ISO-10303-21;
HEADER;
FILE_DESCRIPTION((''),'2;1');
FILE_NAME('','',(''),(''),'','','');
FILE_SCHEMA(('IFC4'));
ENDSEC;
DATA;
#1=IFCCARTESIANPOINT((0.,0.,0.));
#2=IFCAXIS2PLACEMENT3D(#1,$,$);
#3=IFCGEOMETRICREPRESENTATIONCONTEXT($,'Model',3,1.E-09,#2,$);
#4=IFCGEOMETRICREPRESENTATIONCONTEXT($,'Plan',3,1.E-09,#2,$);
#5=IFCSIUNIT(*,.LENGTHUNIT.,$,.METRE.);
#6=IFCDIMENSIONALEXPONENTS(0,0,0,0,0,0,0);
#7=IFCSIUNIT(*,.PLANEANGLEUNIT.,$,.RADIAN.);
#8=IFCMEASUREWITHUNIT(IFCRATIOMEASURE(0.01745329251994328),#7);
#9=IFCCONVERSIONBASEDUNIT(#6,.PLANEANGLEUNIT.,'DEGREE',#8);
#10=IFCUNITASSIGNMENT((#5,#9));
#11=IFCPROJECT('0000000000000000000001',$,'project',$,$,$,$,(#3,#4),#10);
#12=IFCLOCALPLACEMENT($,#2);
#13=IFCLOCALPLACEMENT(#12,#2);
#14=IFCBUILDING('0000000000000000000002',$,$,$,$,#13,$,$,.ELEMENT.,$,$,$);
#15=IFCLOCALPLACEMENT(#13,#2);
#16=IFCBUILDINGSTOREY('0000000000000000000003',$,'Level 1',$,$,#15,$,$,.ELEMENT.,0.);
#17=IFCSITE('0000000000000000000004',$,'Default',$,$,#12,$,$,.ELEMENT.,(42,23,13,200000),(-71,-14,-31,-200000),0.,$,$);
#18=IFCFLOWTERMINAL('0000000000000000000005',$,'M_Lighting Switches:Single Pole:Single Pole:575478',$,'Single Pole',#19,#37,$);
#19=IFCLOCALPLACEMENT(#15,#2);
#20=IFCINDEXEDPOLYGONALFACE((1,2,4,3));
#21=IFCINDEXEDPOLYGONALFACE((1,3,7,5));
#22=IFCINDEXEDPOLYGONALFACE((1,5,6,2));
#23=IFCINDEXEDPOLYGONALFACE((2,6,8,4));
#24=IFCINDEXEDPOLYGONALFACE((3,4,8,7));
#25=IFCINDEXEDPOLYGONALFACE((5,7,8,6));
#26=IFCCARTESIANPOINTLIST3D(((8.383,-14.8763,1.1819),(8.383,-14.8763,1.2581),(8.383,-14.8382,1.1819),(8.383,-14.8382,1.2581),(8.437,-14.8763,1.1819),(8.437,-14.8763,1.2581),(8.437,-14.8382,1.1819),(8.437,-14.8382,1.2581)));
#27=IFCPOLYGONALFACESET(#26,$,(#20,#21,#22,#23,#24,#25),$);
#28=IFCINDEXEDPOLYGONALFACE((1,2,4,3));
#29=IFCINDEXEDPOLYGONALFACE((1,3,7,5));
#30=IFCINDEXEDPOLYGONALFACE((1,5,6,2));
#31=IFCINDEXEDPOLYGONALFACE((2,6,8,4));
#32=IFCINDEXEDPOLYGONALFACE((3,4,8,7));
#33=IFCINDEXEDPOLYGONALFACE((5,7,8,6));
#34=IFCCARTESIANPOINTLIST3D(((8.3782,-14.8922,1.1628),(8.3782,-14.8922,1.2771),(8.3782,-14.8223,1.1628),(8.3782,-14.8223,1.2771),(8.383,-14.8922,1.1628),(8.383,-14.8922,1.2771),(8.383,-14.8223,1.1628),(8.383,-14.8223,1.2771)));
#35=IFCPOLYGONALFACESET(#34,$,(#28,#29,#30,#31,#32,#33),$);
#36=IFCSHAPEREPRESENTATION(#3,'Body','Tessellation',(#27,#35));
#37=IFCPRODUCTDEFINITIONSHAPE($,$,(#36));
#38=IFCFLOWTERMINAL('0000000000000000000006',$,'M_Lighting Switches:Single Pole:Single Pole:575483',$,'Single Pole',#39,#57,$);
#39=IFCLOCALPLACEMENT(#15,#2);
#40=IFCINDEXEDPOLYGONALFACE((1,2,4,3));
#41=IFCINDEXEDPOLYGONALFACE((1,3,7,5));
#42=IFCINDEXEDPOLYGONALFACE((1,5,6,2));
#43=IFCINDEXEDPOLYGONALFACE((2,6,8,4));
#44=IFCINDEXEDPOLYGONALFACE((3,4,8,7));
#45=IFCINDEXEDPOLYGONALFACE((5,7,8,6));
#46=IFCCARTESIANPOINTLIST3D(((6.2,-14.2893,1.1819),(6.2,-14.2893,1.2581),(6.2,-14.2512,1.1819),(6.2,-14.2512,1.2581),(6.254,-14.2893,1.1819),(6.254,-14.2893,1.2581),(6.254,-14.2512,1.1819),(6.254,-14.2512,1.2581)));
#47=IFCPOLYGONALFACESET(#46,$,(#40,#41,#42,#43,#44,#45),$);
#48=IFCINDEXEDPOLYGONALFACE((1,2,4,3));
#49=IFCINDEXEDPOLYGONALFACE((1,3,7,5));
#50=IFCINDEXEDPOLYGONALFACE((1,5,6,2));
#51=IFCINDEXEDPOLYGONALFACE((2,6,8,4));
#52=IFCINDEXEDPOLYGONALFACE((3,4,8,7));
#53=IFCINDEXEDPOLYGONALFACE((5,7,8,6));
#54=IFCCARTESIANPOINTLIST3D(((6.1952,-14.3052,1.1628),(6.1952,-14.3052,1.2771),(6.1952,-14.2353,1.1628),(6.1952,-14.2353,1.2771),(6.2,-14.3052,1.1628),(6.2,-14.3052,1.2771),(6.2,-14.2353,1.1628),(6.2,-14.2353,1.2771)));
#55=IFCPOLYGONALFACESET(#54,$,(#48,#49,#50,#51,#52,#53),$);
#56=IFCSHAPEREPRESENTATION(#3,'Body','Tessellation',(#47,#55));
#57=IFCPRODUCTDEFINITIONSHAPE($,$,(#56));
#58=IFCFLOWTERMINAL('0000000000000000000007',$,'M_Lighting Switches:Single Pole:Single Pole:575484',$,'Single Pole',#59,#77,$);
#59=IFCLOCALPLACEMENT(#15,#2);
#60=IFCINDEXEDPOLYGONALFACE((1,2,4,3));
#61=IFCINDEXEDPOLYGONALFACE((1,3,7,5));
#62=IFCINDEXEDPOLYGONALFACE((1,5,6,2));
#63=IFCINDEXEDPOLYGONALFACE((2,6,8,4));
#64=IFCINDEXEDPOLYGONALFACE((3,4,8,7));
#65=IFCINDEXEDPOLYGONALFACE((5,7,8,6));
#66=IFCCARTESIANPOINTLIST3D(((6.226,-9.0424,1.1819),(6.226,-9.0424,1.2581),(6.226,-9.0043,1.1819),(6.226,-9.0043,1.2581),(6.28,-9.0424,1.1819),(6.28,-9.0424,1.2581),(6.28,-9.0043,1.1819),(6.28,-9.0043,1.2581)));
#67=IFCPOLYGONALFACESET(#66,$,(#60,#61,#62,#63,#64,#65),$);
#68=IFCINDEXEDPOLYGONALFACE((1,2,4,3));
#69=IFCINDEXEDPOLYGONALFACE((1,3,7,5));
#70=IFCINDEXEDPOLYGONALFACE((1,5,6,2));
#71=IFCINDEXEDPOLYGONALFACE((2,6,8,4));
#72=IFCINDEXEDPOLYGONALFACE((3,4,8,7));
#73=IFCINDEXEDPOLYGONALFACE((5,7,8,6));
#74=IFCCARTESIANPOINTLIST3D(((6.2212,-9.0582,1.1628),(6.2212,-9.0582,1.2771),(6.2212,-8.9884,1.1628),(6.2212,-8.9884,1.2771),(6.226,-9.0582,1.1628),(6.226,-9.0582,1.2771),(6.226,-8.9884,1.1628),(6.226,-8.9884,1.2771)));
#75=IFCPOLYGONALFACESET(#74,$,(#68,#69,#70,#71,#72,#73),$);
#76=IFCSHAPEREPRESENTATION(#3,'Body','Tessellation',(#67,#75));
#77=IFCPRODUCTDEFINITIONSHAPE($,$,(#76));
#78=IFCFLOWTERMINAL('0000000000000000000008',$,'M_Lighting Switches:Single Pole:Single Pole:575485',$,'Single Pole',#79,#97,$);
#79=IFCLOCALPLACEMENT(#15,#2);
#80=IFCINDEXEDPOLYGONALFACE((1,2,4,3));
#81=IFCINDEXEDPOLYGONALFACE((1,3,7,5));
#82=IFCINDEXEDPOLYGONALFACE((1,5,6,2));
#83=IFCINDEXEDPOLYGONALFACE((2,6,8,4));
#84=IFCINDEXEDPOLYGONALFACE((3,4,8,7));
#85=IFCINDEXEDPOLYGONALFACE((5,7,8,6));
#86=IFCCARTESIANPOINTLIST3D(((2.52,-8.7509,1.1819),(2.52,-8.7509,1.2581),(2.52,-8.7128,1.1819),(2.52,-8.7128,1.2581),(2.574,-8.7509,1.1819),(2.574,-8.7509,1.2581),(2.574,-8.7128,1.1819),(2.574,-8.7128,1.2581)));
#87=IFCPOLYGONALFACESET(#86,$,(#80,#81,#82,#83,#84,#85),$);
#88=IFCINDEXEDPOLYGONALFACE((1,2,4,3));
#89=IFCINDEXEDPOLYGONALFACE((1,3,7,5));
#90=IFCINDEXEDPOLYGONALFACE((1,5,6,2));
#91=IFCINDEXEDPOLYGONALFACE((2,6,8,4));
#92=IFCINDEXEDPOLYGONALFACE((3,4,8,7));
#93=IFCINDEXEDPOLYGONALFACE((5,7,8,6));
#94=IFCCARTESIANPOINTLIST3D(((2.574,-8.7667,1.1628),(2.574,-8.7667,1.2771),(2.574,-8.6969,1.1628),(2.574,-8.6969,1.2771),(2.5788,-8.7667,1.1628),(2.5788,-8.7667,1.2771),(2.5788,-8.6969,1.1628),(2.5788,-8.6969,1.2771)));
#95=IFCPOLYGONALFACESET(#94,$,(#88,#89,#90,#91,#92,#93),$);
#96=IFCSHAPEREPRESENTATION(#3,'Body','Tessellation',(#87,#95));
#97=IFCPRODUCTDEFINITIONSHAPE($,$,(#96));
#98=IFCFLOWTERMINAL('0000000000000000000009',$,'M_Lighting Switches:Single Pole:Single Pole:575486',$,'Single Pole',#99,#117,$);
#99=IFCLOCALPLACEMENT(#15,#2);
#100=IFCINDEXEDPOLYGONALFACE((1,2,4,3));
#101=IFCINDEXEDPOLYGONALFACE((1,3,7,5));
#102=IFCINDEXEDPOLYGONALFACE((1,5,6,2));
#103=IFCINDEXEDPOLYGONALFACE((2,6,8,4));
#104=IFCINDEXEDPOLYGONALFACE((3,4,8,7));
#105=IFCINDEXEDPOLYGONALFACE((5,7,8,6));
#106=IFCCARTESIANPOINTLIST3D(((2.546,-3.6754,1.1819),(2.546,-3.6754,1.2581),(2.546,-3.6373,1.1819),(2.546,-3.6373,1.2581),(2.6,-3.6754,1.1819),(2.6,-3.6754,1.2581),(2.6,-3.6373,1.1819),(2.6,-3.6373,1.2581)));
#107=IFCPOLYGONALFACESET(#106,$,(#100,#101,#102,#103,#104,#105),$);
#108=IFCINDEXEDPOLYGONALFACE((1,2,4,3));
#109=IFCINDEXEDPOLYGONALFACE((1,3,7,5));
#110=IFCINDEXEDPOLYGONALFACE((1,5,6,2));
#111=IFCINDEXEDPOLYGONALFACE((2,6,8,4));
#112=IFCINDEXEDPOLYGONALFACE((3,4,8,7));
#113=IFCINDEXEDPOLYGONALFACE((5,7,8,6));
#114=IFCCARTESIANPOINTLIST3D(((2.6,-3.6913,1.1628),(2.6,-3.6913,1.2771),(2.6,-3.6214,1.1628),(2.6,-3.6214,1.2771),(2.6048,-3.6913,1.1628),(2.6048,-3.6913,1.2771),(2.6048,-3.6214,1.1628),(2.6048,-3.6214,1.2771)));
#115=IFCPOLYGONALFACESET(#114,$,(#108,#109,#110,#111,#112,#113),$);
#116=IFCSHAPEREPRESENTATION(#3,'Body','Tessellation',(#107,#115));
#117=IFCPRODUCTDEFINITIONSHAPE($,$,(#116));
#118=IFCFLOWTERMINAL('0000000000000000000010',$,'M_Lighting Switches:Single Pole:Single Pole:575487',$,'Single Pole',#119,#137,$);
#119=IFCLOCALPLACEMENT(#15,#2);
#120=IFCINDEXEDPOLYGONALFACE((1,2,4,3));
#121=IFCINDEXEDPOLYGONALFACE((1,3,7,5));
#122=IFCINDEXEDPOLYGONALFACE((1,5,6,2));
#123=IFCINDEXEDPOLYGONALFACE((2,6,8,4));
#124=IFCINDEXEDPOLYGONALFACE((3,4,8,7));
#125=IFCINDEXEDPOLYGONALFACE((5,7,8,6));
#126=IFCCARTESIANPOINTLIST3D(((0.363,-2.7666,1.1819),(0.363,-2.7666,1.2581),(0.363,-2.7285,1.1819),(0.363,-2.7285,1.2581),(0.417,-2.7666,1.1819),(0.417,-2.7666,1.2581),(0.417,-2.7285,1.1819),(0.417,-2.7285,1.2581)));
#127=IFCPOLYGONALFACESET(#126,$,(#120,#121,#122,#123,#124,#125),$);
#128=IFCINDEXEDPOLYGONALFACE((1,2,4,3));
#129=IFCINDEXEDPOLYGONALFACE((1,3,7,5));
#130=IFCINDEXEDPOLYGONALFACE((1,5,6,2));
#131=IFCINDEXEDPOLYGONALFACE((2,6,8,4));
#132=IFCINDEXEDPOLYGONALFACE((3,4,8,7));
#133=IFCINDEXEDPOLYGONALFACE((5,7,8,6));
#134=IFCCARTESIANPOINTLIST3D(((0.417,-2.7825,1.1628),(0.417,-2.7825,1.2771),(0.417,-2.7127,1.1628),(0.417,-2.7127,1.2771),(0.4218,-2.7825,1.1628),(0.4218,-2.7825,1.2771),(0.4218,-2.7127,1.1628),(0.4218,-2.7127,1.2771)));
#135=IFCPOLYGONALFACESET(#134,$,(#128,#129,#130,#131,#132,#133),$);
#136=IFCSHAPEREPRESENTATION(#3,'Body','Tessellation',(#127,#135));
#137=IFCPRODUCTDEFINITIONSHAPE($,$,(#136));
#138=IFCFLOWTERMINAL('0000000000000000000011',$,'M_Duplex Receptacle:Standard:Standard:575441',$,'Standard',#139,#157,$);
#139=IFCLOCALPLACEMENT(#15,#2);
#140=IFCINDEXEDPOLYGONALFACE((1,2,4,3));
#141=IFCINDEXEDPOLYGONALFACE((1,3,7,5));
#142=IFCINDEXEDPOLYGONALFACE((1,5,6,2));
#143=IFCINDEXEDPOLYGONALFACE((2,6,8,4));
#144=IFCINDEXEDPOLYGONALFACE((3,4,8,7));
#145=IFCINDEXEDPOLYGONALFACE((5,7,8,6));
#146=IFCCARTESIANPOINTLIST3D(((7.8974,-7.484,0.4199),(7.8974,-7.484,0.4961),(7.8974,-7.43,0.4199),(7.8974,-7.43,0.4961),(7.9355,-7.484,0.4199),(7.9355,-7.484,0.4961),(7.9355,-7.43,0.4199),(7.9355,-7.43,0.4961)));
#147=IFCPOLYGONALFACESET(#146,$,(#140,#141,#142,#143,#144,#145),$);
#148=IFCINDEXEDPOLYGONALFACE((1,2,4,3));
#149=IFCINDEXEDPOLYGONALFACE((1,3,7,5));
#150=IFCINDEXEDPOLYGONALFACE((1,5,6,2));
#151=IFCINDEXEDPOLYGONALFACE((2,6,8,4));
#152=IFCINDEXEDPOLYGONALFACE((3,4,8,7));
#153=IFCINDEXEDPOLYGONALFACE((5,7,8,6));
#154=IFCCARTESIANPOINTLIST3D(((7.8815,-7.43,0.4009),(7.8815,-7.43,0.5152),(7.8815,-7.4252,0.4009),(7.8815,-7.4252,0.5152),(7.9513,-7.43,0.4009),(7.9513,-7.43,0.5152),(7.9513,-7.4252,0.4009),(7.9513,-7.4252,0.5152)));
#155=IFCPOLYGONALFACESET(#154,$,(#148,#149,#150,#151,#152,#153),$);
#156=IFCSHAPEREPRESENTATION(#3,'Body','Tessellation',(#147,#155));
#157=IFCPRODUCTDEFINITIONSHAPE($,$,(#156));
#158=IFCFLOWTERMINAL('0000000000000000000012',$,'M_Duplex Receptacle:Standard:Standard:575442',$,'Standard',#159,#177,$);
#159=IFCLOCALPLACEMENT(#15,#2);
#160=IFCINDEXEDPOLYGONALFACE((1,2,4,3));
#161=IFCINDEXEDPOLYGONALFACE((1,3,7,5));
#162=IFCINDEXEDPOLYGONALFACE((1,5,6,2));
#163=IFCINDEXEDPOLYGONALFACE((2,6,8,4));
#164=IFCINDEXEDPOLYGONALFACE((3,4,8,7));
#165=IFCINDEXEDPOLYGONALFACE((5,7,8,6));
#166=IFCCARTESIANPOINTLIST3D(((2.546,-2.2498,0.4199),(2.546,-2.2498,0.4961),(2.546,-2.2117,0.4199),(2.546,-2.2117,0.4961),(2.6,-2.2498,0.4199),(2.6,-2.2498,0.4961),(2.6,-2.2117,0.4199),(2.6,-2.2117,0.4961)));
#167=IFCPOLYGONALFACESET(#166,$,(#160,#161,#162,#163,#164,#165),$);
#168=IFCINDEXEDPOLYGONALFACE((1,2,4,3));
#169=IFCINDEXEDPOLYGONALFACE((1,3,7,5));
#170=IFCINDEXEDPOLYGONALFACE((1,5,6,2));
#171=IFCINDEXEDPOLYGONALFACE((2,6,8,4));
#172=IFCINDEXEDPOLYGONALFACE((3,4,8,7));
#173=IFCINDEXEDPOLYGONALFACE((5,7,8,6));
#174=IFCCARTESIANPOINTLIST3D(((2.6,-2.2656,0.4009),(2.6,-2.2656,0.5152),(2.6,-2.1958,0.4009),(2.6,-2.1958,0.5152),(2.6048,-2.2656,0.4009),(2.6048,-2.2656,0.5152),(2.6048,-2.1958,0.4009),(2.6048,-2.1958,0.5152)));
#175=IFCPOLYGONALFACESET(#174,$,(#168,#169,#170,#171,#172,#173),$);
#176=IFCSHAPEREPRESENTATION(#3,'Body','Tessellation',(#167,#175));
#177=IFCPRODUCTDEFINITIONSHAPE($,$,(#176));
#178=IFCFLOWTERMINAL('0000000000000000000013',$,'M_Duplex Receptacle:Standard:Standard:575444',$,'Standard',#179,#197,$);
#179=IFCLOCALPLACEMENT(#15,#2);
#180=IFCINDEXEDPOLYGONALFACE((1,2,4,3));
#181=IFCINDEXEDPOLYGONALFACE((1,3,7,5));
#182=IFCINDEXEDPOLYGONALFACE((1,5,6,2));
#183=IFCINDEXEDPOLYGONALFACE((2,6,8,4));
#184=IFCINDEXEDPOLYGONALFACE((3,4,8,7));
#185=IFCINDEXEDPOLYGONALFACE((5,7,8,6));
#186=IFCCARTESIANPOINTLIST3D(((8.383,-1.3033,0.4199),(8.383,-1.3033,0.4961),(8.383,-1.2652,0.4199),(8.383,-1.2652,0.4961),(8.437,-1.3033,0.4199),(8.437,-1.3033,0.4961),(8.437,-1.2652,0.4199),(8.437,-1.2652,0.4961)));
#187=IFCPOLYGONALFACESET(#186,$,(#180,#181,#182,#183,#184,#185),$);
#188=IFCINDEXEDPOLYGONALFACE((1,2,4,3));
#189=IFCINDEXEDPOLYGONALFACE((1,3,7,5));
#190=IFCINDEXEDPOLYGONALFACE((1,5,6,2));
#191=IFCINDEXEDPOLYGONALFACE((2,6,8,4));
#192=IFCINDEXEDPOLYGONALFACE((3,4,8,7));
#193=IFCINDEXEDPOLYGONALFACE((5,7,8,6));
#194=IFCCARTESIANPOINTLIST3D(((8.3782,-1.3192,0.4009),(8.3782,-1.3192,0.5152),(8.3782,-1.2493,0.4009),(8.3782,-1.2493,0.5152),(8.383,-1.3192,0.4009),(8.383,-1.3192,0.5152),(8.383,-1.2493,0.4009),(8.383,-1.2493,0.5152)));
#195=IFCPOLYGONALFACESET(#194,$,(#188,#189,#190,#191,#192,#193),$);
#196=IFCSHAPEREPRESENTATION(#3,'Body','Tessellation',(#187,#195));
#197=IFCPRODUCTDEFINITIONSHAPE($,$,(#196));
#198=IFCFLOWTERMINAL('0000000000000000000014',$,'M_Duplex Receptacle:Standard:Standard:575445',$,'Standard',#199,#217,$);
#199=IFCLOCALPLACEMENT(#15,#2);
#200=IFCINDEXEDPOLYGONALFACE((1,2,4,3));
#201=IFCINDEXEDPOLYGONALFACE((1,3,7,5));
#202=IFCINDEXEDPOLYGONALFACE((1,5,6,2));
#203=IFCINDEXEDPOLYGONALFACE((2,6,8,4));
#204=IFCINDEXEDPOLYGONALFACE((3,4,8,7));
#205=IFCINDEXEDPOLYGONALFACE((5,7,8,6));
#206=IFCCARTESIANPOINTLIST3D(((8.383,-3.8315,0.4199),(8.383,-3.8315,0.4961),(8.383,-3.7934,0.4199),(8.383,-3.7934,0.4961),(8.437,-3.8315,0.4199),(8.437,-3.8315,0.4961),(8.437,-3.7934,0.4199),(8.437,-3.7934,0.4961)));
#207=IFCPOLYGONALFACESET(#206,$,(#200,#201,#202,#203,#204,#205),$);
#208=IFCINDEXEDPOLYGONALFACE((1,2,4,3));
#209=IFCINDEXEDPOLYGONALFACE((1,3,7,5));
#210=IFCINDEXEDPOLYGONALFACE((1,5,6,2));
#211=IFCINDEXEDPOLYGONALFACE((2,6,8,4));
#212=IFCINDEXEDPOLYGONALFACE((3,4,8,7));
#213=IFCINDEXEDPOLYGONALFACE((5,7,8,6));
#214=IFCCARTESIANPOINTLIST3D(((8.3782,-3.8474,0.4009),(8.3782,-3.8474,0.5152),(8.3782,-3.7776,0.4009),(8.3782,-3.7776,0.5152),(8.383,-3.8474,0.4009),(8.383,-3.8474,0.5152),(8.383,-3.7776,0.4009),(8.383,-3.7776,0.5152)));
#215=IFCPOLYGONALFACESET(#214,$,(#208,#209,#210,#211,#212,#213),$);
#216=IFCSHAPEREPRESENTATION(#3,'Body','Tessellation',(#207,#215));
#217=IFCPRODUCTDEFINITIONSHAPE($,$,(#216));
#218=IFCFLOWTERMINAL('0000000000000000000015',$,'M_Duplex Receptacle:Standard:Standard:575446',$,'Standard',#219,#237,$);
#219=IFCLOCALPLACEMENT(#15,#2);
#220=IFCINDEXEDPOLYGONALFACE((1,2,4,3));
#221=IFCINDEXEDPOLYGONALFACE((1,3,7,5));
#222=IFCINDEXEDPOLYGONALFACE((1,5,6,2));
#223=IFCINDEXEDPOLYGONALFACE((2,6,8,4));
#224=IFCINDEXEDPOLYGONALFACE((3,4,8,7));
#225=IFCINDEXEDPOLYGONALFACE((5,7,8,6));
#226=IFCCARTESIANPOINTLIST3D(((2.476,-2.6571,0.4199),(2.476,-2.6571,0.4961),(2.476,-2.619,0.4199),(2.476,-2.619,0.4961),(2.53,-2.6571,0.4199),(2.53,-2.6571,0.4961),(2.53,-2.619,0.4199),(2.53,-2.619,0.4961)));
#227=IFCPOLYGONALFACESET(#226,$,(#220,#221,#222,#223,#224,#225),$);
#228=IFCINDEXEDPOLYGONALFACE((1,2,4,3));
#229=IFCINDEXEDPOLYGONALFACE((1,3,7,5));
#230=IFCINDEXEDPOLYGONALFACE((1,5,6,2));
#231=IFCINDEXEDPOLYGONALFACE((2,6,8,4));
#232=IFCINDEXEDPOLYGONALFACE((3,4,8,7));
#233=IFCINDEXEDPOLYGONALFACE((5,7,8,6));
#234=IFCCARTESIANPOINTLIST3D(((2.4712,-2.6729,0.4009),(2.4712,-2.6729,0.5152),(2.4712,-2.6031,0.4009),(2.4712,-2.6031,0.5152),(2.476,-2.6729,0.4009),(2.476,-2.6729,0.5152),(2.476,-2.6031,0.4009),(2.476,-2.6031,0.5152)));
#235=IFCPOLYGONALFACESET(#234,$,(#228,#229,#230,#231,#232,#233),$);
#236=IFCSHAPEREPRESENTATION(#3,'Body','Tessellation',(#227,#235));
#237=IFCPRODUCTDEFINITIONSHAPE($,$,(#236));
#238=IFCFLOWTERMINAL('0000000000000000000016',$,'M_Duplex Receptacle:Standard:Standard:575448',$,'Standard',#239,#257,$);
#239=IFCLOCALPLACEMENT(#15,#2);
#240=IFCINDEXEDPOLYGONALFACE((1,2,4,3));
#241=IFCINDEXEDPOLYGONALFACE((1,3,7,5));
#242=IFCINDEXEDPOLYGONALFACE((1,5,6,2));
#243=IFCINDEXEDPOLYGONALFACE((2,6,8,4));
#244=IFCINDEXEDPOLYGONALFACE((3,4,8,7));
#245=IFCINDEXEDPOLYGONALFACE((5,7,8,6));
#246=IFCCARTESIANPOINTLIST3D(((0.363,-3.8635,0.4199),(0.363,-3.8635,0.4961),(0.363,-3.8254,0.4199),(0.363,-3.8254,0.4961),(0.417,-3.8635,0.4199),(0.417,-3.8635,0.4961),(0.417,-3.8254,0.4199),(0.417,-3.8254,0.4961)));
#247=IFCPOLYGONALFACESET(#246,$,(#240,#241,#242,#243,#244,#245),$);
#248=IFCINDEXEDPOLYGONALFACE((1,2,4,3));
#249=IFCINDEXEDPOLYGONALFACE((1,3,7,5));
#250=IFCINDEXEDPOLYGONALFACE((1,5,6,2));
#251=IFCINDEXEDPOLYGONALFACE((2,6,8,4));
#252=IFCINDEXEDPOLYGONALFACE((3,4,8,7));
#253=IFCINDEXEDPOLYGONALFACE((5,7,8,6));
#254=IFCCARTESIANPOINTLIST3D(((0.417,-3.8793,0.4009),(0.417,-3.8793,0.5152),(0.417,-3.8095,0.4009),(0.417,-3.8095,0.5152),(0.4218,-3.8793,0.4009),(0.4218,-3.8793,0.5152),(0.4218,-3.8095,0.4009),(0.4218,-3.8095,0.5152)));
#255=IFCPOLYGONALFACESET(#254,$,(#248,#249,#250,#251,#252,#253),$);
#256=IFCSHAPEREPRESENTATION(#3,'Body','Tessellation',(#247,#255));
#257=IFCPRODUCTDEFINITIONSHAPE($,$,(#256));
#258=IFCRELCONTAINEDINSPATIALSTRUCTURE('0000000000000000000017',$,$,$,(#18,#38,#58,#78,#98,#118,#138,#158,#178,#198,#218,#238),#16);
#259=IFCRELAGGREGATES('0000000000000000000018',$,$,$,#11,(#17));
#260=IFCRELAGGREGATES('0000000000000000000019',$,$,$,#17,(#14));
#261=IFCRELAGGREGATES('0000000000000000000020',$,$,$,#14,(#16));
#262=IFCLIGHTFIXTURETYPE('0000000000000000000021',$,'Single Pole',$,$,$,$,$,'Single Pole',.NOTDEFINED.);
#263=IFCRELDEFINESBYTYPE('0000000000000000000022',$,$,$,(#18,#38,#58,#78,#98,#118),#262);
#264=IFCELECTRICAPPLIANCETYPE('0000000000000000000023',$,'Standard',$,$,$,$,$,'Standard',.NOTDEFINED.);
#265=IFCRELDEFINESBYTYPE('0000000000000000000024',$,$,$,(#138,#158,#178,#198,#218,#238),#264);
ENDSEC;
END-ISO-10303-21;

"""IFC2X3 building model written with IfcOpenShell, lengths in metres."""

from ifc_helpers import new_model, entity, si_unit, converted_unit, frame, origin, origin_2d_with_axis, place, context, project, spatial, rectangle, extrude, source, transform, mapped, type_object, type_shapes, element, save


model = new_model("IFC2X3")

# Units and contexts
model_context = context("Model", 3, precision=1e-09, world=origin())
plan_context = context("Plan", 3, precision=1e-09, world=origin())
ifc_project = project(units=[si_unit("LENGTHUNIT", "METRE"), converted_unit("PLANEANGLEUNIT", "DEGREE", entity("IfcRatioMeasure", 0.01745329251994328), si_unit("PLANEANGLEUNIT", "RADIAN"), dimensions=[0, 0, 0, 0, 0, 0, 0])], contexts=[model_context, plan_context])

# Site, building, storey
site_placement = place(None, origin())
site = spatial("IfcSite", under=ifc_project, at=site_placement, Name="Default", CompositionType="ELEMENT", RefLatitude=(42, 23, 13, 200000), RefLongitude=(-71, -14, -31, -200000), RefElevation=0.0)
building_placement = place(site_placement, origin())
building = spatial("IfcBuilding", under=site, at=building_placement, CompositionType="ELEMENT")
storey_placement = place(building_placement, origin())
storey = spatial("IfcBuildingStorey", under=building, at=storey_placement, Name="Level 1", CompositionType="ELEMENT", Elevation=0.0)

# Flow terminals
light_fixture_type = type_object("IfcLightFixtureType", Name="Single Pole", ElementType="Single Pole", PredefinedType="NOTDEFINED")
shared_shape_1 = source(origin(), model_context, "Body", "SweptSolid", [
    extrude(rectangle(XDim=0.0381, YDim=0.0762, at=origin_2d_with_axis()), frame((0.0, 0.0, -0.054), z_axis=(0.0, 0.0, 1.0), x_axis=(-1.0, 0.0, 0.0)), (0.0, 0.0, 1.0), 0.054),
    extrude(rectangle(XDim=0.0698, YDim=0.1143, at=origin_2d_with_axis()), frame((0.0, 0.0, 0.0), z_axis=(0.0, 0.0, 1.0), x_axis=(-1.0, 0.0, 0.0)), (0.0, 0.0, 1.0), 0.0048),
])
type_shapes(light_fixture_type, [shared_shape_1])
for number, where, z_axis, x_axis, name in (
    (1, (8.383, -14.8573, 1.22), (-1.0, 0.0, 0.0), (0.0, -1.0, 0.0), "M_Lighting Switches:Single Pole:Single Pole:575478"),
    (2, (6.2, -14.2702, 1.22), (-1.0, 0.0, 0.0), (0.0, -1.0, 0.0), "M_Lighting Switches:Single Pole:Single Pole:575483"),
    (3, (6.226, -9.0233, 1.22), (-1.0, 0.0, 0.0), (0.0, -1.0, 0.0), "M_Lighting Switches:Single Pole:Single Pole:575484"),
    (4, (2.574, -8.7318, 1.22), (1.0, 0.0, 0.0), (0.0, 1.0, 0.0), "M_Lighting Switches:Single Pole:Single Pole:575485"),
    (5, (2.6, -3.6564, 1.22), (1.0, 0.0, 0.0), (0.0, 1.0, 0.0), "M_Lighting Switches:Single Pole:Single Pole:575486"),
    (6, (0.417, -2.7476, 1.22), (1.0, 0.0, 0.0), (0.0, 1.0, 0.0), "M_Lighting Switches:Single Pole:Single Pole:575487"),
):
    element("IfcFlowTerminal", number, at=place(storey_placement, frame(where, z_axis=z_axis, x_axis=x_axis)), inside=storey, type_object=light_fixture_type, Name=name, ObjectType="Single Pole", context=model_context, shape_type="MappedRepresentation", body=[
        mapped(shared_shape_1, transform((0.0, 0.0, 0.0), scale=1.0)),
    ])
electric_appliance_type_1 = type_object("IfcElectricApplianceType", Name="Standard", ElementType="Standard", PredefinedType="NOTDEFINED")
shared_shape_2 = source(origin(), model_context, "Body", "SweptSolid", [
    extrude(rectangle(XDim=0.0381, YDim=0.0762, at=origin_2d_with_axis()), frame((0.0, 0.0, -0.054), z_axis=(0.0, 0.0, 1.0), x_axis=(-1.0, 0.0, 0.0)), (0.0, 0.0, 1.0), 0.054),
    extrude(rectangle(XDim=0.0698, YDim=0.1143, at=origin_2d_with_axis()), frame((0.0, 0.0, 0.0), z_axis=(0.0, 0.0, 1.0), x_axis=(-1.0, 0.0, 0.0)), (0.0, 0.0, 1.0), 0.0048),
])
type_shapes(electric_appliance_type_1, [shared_shape_2])
for number, where, z_axis, x_axis, name in (
    (7, (7.9164, -7.43, 0.458), (0.0, 1.0, 0.0), (-1.0, 0.0, 0.0), "M_Duplex Receptacle:Standard:Standard:575441"),
    (8, (2.6, -2.2307, 0.458), (1.0, 0.0, 0.0), (0.0, 1.0, 0.0), "M_Duplex Receptacle:Standard:Standard:575442"),
    (9, (8.383, -1.2842, 0.458), (-1.0, 0.0, 0.0), (0.0, -1.0, 0.0), "M_Duplex Receptacle:Standard:Standard:575444"),
    (10, (8.383, -3.8125, 0.458), (-1.0, 0.0, 0.0), (0.0, -1.0, 0.0), "M_Duplex Receptacle:Standard:Standard:575445"),
    (11, (2.476, -2.638, 0.458), (-1.0, 0.0, 0.0), (0.0, -1.0, 0.0), "M_Duplex Receptacle:Standard:Standard:575446"),
    (12, (0.417, -3.8444, 0.458), (1.0, 0.0, 0.0), (0.0, 1.0, 0.0), "M_Duplex Receptacle:Standard:Standard:575448"),
):
    element("IfcFlowTerminal", number, at=place(storey_placement, frame(where, z_axis=z_axis, x_axis=x_axis)), inside=storey, type_object=electric_appliance_type_1, Name=name, ObjectType="Standard", context=model_context, shape_type="MappedRepresentation", body=[
        mapped(shared_shape_2, transform((0.0, 0.0, 0.0), scale=1.0)),
    ])

save(model, "model.ifc")
